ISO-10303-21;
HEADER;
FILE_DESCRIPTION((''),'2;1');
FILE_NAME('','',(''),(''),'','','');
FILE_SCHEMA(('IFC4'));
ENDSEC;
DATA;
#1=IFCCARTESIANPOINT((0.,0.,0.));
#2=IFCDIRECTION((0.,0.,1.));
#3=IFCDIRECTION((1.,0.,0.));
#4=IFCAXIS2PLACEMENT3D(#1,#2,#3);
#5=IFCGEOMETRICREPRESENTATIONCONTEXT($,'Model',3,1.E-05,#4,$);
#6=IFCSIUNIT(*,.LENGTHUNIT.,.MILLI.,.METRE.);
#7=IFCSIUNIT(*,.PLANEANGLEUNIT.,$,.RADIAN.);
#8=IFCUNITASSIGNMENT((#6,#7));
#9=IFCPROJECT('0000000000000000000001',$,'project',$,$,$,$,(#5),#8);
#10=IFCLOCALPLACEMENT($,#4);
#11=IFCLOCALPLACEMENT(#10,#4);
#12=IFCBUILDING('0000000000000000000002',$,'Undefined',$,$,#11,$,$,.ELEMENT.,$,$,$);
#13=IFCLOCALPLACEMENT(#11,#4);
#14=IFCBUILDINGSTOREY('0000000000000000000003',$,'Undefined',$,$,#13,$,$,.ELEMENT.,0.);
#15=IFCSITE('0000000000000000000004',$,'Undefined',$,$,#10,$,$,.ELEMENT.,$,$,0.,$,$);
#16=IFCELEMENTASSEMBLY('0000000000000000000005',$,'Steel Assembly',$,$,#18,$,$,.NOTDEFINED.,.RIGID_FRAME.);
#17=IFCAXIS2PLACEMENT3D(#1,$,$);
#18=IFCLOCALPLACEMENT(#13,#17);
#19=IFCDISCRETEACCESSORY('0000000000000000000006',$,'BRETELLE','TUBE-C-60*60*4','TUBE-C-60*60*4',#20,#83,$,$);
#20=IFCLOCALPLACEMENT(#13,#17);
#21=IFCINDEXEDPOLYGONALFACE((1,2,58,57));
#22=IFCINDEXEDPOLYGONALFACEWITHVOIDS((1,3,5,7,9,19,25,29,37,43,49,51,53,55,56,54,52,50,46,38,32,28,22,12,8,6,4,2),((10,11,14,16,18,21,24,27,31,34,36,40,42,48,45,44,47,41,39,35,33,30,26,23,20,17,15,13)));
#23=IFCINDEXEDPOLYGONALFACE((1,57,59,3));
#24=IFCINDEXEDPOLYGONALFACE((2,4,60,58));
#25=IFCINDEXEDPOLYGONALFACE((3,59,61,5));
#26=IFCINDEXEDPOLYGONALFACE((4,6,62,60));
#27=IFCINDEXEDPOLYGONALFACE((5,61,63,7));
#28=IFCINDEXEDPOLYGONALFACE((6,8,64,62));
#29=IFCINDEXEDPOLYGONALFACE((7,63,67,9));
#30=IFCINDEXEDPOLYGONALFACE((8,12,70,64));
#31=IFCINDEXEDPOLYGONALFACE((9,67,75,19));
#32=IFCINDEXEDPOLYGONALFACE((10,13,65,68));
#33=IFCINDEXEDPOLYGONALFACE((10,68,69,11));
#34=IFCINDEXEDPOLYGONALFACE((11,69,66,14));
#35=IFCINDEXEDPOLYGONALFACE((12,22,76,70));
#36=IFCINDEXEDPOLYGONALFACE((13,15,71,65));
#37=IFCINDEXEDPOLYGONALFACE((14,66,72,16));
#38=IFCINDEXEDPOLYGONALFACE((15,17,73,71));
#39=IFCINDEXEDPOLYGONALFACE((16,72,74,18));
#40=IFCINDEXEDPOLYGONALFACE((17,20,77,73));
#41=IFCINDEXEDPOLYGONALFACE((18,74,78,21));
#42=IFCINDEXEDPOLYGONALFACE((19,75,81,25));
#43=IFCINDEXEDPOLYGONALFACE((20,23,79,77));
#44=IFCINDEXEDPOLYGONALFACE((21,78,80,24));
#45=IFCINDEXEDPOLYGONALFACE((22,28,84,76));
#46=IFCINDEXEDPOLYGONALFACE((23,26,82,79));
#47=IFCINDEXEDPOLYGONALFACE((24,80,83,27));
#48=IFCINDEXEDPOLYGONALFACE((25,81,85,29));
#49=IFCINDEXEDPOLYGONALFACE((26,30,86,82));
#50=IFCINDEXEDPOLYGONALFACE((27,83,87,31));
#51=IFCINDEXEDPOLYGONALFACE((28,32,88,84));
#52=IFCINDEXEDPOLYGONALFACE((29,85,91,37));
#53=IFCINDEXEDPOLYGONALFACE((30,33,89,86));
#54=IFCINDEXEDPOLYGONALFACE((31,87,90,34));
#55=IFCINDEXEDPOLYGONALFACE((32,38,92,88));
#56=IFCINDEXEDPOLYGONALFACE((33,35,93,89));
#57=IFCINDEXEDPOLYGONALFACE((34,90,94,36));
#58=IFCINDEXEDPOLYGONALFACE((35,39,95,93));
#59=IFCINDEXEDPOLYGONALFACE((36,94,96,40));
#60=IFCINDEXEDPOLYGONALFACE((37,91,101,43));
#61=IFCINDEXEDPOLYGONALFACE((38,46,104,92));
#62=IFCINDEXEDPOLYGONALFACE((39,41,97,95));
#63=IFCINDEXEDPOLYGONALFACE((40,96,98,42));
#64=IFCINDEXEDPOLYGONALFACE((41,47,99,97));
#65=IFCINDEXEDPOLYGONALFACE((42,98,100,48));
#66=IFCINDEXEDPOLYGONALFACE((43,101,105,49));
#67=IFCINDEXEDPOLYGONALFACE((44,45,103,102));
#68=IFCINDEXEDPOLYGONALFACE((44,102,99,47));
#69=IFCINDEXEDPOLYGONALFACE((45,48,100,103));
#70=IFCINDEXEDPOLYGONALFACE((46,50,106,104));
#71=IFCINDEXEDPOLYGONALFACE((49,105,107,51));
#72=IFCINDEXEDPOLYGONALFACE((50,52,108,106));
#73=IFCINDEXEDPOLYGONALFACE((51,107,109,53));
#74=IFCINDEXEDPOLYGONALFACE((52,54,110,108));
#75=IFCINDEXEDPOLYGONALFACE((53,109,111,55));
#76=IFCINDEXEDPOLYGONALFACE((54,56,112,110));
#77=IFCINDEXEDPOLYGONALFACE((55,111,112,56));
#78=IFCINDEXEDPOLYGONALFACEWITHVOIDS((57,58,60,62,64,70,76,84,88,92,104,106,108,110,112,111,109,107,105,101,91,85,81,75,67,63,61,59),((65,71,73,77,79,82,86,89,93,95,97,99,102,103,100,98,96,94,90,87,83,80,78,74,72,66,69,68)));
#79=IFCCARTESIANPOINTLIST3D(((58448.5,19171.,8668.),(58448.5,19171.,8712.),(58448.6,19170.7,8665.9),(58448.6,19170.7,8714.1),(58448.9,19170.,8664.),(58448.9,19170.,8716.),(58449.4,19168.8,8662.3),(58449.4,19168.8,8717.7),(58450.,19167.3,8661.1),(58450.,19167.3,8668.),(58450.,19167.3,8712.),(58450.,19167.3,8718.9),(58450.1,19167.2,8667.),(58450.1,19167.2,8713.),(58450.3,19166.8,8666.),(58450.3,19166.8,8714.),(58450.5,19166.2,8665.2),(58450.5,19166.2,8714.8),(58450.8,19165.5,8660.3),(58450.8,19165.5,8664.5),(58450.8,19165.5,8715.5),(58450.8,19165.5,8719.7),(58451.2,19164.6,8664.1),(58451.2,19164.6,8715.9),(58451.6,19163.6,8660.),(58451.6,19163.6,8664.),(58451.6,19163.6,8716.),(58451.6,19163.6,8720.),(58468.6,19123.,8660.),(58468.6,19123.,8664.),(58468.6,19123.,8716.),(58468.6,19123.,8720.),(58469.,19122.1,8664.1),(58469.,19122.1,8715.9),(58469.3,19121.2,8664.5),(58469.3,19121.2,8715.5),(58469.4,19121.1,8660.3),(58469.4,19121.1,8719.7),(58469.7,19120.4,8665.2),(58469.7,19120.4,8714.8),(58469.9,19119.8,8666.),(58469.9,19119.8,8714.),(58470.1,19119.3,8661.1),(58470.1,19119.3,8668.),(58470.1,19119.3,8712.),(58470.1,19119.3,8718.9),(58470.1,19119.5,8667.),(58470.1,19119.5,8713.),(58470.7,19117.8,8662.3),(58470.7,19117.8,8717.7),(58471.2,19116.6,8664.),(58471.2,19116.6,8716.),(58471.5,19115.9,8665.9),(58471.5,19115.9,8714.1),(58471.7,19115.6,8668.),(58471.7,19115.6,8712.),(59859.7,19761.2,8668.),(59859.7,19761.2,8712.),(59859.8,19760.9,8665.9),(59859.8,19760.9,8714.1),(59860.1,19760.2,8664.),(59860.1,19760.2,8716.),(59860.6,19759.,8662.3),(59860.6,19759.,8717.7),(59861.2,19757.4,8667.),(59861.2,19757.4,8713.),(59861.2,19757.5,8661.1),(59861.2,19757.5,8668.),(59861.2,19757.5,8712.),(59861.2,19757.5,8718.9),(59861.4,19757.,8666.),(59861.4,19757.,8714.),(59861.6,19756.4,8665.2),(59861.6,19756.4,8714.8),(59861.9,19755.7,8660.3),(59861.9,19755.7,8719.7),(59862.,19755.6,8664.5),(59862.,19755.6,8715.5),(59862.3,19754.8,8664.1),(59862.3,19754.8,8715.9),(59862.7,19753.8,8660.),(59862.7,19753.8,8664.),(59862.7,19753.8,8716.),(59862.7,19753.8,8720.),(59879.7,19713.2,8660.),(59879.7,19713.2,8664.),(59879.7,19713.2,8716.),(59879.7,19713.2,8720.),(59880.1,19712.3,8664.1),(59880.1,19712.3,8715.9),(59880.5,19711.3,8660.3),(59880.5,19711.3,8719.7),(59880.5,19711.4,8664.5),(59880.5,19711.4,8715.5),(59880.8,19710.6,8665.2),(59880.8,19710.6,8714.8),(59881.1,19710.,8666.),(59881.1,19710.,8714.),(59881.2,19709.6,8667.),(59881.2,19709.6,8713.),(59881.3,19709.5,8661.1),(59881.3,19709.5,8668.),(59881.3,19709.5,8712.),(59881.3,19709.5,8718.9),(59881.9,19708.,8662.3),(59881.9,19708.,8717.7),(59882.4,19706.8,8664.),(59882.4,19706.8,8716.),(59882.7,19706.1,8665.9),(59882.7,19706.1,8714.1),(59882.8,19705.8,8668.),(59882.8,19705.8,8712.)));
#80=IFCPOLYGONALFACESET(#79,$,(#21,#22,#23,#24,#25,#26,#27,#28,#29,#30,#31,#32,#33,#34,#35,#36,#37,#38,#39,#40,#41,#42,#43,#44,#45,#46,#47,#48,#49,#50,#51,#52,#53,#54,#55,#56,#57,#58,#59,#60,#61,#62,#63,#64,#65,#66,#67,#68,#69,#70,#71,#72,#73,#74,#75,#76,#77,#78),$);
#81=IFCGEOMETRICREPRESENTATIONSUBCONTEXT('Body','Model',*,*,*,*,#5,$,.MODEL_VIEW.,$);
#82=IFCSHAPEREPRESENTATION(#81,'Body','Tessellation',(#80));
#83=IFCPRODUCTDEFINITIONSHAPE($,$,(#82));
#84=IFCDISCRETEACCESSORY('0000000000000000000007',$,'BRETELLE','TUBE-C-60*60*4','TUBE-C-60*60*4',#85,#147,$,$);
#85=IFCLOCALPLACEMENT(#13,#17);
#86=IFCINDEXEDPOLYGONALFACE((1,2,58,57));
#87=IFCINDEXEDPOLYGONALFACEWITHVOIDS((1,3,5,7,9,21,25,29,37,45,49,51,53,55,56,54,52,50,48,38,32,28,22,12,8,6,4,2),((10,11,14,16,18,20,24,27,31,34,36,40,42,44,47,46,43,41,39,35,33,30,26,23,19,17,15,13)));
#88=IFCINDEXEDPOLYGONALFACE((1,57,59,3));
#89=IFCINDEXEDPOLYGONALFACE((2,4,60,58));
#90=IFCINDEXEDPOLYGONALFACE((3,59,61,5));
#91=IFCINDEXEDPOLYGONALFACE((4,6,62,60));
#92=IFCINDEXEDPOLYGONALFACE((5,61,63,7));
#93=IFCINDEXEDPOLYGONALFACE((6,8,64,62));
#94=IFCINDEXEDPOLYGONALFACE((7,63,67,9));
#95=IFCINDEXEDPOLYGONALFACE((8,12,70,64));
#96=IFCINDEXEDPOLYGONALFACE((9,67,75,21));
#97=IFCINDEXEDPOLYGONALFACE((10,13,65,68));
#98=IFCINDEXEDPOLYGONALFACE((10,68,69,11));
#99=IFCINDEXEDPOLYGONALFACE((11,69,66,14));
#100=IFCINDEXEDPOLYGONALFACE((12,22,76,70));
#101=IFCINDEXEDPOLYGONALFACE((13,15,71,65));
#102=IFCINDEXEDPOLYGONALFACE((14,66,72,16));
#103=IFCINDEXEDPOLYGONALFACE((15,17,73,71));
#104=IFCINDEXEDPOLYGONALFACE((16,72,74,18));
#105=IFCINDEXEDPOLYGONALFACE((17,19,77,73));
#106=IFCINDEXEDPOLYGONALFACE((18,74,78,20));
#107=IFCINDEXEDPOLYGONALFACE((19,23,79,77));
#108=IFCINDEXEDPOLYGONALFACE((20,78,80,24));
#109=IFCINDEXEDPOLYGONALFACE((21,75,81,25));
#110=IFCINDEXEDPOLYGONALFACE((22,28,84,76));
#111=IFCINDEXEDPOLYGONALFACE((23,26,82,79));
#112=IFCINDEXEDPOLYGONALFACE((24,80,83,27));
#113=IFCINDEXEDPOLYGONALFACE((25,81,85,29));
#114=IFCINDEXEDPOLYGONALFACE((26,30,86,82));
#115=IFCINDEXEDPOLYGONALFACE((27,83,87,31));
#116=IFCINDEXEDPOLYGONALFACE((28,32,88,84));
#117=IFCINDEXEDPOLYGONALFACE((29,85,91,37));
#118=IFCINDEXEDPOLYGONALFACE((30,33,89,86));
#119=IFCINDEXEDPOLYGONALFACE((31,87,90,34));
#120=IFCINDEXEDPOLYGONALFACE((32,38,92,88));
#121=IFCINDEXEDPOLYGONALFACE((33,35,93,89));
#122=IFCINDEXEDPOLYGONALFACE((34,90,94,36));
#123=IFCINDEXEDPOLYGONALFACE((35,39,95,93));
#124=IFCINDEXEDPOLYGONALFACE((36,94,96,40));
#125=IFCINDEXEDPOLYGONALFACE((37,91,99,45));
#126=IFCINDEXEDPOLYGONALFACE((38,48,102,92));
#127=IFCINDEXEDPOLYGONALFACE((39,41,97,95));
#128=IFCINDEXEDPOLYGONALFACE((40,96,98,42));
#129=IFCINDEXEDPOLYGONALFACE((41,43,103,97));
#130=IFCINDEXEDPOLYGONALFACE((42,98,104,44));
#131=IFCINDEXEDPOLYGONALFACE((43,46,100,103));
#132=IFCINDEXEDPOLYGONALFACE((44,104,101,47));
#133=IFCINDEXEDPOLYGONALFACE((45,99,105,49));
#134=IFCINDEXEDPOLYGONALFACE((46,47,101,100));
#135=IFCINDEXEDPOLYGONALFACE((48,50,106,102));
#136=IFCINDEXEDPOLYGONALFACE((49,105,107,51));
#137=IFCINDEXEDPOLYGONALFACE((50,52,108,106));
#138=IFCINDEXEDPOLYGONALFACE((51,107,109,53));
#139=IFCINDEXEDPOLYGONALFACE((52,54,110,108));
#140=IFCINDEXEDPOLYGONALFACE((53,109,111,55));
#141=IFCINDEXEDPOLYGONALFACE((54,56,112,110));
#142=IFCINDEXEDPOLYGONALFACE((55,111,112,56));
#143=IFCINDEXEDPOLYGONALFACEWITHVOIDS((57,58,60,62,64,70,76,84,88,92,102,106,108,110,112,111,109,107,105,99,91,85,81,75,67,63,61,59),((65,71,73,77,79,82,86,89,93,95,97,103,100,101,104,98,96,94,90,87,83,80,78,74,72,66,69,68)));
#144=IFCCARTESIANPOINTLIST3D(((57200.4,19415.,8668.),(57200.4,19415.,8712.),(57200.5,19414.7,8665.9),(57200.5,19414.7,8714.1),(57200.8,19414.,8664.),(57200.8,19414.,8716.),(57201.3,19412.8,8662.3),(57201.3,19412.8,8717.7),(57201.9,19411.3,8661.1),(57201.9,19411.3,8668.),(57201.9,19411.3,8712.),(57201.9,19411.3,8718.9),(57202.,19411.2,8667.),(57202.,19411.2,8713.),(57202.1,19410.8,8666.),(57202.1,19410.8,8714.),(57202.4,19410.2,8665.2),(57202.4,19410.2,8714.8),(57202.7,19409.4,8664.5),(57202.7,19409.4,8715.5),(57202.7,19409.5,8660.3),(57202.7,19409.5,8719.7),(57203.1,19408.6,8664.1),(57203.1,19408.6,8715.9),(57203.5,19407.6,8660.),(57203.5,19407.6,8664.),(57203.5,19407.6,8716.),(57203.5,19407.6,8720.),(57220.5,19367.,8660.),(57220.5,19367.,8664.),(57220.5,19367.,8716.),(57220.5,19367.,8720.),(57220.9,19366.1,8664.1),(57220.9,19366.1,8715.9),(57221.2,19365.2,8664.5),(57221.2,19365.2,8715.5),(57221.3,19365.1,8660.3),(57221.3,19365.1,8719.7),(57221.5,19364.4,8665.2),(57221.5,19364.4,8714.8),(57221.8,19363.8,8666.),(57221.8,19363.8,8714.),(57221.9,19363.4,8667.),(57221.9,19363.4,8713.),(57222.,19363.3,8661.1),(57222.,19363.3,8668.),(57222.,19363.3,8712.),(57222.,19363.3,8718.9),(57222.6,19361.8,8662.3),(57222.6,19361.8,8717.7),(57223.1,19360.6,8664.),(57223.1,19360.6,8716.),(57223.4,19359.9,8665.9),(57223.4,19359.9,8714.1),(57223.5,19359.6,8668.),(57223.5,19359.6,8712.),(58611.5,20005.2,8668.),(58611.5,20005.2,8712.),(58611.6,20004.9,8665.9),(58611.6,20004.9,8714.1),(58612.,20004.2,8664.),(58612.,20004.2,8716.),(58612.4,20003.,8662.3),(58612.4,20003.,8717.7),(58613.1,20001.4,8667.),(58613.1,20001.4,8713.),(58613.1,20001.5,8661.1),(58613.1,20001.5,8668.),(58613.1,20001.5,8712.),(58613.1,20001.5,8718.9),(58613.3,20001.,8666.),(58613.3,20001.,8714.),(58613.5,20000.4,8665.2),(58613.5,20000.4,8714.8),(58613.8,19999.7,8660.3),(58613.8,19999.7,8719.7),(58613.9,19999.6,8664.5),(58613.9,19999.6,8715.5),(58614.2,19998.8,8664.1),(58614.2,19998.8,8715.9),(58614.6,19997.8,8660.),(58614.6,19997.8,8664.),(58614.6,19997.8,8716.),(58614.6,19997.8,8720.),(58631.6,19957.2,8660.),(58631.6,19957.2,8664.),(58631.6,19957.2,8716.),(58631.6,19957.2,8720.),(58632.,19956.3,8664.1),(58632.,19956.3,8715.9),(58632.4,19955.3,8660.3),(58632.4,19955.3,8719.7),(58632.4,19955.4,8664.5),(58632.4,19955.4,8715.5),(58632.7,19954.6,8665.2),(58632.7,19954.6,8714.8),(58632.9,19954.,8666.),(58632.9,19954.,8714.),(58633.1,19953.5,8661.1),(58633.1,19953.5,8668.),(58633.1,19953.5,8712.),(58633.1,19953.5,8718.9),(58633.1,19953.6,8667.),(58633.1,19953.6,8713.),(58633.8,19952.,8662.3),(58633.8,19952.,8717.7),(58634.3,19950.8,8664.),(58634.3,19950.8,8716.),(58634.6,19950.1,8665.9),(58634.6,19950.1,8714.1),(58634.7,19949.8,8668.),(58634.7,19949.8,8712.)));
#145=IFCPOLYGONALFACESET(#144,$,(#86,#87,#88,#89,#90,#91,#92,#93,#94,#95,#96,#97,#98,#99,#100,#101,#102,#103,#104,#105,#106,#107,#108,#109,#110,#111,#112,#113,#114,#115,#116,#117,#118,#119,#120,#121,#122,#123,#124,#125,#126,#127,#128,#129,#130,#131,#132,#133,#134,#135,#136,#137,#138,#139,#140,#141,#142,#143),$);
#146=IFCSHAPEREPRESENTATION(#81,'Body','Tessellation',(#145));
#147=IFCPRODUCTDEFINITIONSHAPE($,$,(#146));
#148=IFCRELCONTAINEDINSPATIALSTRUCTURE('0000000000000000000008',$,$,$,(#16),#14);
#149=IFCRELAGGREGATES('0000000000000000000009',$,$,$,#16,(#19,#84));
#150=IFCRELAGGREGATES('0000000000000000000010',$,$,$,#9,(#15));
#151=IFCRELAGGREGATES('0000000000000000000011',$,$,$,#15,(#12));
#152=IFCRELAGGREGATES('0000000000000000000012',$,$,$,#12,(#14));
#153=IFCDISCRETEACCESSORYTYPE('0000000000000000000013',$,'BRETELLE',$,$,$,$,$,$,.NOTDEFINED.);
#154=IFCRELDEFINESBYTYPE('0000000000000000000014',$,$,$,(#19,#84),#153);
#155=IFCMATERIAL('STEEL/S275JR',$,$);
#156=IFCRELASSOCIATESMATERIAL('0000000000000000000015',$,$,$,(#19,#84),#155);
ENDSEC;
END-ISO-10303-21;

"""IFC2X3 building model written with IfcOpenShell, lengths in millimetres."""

from ifc_helpers import new_model, si_unit, frame, origin_with_axes, origin_2d_with_axis, place, context, subcontext, project, spatial, hollow_rectangle, extrude, material, type_object, element, aggregate, save


model = new_model("IFC2X3")

# Units and contexts
model_context = context("Model", 3, precision=1e-05, world=origin_with_axes())
body_context = subcontext(model_context, "Body", "Model", "MODEL_VIEW")
ifc_project = project(units=[si_unit("LENGTHUNIT", "METRE", prefix="MILLI"), si_unit("PLANEANGLEUNIT", "RADIAN")], contexts=[model_context])

# Site, building, storey
site_placement = place(None, origin_with_axes())
site = spatial("IfcSite", under=ifc_project, at=site_placement, Name="Undefined", CompositionType="ELEMENT", RefElevation=0.0)
building_placement = place(site_placement, origin_with_axes())
building = spatial("IfcBuilding", under=site, at=building_placement, Name="Undefined", CompositionType="ELEMENT")
storey_placement = place(building_placement, origin_with_axes())
storey = spatial("IfcBuildingStorey", under=building, at=storey_placement, Name="Undefined", CompositionType="ELEMENT", Elevation=0.0)

# Shared definitions
ifc_material_1 = material(Name="STEEL/S275JR")

# Element assembly, discrete accessories
assembly_1_placement = place(storey_placement, origin_with_axes())
assembly_1 = element("IfcElementAssembly", 1, at=assembly_1_placement, inside=storey, Name="Steel Assembly", AssemblyPlace="NOTDEFINED", PredefinedType="RIGID_FRAME")
discrete_accessory_type_1 = type_object("IfcDiscreteAccessoryType", Name="BRETELLE")
discrete_accessory_1_placement = place(assembly_1_placement, frame((59871.3, 19733.5, 8690.0), z_axis=(-0.385849, 0.922562, 0.0), x_axis=(-0.922562, -0.385849, 0.0)))
discrete_accessory_1 = element("IfcDiscreteAccessory", 2, at=discrete_accessory_1_placement, type_object=discrete_accessory_type_1, material=ifc_material_1, Name="BRETELLE", Description="TUBE-C-60*60*4", ObjectType="TUBE-C-60*60*4", context=body_context, shape_type="SweptSolid", body=[
    extrude(hollow_rectangle(XDim=60.0, YDim=60.0, WallThickness=4.0, InnerFilletRadius=4.0, OuterFilletRadius=8.0, at=origin_2d_with_axis()), frame((1529.6, 0.0, 0.0), z_axis=(-1.0, 0.0, 0.0), x_axis=(0.0, -1.0, 0.0)), (0.0, 0.0, 1.0), 1529.6),
])
discrete_accessory_2_placement = place(assembly_1_placement, frame((58623.2, 19977.5, 8690.0), z_axis=(-0.38585, 0.922561, 0.0), x_axis=(-0.922561, -0.38585, 0.0)))
discrete_accessory_2 = element("IfcDiscreteAccessory", 3, at=discrete_accessory_2_placement, type_object=discrete_accessory_type_1, material=ifc_material_1, Name="BRETELLE", Description="TUBE-C-60*60*4", ObjectType="TUBE-C-60*60*4", context=body_context, shape_type="SweptSolid", body=[
    extrude(hollow_rectangle(XDim=60.0, YDim=60.0, WallThickness=4.0, InnerFilletRadius=4.0, OuterFilletRadius=8.0, at=origin_2d_with_axis()), frame((1529.6, 0.0, 0.0), z_axis=(-1.0, 0.0, 0.0), x_axis=(0.0, -1.0, 0.0)), (0.0, 0.0, 1.0), 1529.6),
])
aggregate(assembly_1, [discrete_accessory_1, discrete_accessory_2])

save(model, "model.ifc")
